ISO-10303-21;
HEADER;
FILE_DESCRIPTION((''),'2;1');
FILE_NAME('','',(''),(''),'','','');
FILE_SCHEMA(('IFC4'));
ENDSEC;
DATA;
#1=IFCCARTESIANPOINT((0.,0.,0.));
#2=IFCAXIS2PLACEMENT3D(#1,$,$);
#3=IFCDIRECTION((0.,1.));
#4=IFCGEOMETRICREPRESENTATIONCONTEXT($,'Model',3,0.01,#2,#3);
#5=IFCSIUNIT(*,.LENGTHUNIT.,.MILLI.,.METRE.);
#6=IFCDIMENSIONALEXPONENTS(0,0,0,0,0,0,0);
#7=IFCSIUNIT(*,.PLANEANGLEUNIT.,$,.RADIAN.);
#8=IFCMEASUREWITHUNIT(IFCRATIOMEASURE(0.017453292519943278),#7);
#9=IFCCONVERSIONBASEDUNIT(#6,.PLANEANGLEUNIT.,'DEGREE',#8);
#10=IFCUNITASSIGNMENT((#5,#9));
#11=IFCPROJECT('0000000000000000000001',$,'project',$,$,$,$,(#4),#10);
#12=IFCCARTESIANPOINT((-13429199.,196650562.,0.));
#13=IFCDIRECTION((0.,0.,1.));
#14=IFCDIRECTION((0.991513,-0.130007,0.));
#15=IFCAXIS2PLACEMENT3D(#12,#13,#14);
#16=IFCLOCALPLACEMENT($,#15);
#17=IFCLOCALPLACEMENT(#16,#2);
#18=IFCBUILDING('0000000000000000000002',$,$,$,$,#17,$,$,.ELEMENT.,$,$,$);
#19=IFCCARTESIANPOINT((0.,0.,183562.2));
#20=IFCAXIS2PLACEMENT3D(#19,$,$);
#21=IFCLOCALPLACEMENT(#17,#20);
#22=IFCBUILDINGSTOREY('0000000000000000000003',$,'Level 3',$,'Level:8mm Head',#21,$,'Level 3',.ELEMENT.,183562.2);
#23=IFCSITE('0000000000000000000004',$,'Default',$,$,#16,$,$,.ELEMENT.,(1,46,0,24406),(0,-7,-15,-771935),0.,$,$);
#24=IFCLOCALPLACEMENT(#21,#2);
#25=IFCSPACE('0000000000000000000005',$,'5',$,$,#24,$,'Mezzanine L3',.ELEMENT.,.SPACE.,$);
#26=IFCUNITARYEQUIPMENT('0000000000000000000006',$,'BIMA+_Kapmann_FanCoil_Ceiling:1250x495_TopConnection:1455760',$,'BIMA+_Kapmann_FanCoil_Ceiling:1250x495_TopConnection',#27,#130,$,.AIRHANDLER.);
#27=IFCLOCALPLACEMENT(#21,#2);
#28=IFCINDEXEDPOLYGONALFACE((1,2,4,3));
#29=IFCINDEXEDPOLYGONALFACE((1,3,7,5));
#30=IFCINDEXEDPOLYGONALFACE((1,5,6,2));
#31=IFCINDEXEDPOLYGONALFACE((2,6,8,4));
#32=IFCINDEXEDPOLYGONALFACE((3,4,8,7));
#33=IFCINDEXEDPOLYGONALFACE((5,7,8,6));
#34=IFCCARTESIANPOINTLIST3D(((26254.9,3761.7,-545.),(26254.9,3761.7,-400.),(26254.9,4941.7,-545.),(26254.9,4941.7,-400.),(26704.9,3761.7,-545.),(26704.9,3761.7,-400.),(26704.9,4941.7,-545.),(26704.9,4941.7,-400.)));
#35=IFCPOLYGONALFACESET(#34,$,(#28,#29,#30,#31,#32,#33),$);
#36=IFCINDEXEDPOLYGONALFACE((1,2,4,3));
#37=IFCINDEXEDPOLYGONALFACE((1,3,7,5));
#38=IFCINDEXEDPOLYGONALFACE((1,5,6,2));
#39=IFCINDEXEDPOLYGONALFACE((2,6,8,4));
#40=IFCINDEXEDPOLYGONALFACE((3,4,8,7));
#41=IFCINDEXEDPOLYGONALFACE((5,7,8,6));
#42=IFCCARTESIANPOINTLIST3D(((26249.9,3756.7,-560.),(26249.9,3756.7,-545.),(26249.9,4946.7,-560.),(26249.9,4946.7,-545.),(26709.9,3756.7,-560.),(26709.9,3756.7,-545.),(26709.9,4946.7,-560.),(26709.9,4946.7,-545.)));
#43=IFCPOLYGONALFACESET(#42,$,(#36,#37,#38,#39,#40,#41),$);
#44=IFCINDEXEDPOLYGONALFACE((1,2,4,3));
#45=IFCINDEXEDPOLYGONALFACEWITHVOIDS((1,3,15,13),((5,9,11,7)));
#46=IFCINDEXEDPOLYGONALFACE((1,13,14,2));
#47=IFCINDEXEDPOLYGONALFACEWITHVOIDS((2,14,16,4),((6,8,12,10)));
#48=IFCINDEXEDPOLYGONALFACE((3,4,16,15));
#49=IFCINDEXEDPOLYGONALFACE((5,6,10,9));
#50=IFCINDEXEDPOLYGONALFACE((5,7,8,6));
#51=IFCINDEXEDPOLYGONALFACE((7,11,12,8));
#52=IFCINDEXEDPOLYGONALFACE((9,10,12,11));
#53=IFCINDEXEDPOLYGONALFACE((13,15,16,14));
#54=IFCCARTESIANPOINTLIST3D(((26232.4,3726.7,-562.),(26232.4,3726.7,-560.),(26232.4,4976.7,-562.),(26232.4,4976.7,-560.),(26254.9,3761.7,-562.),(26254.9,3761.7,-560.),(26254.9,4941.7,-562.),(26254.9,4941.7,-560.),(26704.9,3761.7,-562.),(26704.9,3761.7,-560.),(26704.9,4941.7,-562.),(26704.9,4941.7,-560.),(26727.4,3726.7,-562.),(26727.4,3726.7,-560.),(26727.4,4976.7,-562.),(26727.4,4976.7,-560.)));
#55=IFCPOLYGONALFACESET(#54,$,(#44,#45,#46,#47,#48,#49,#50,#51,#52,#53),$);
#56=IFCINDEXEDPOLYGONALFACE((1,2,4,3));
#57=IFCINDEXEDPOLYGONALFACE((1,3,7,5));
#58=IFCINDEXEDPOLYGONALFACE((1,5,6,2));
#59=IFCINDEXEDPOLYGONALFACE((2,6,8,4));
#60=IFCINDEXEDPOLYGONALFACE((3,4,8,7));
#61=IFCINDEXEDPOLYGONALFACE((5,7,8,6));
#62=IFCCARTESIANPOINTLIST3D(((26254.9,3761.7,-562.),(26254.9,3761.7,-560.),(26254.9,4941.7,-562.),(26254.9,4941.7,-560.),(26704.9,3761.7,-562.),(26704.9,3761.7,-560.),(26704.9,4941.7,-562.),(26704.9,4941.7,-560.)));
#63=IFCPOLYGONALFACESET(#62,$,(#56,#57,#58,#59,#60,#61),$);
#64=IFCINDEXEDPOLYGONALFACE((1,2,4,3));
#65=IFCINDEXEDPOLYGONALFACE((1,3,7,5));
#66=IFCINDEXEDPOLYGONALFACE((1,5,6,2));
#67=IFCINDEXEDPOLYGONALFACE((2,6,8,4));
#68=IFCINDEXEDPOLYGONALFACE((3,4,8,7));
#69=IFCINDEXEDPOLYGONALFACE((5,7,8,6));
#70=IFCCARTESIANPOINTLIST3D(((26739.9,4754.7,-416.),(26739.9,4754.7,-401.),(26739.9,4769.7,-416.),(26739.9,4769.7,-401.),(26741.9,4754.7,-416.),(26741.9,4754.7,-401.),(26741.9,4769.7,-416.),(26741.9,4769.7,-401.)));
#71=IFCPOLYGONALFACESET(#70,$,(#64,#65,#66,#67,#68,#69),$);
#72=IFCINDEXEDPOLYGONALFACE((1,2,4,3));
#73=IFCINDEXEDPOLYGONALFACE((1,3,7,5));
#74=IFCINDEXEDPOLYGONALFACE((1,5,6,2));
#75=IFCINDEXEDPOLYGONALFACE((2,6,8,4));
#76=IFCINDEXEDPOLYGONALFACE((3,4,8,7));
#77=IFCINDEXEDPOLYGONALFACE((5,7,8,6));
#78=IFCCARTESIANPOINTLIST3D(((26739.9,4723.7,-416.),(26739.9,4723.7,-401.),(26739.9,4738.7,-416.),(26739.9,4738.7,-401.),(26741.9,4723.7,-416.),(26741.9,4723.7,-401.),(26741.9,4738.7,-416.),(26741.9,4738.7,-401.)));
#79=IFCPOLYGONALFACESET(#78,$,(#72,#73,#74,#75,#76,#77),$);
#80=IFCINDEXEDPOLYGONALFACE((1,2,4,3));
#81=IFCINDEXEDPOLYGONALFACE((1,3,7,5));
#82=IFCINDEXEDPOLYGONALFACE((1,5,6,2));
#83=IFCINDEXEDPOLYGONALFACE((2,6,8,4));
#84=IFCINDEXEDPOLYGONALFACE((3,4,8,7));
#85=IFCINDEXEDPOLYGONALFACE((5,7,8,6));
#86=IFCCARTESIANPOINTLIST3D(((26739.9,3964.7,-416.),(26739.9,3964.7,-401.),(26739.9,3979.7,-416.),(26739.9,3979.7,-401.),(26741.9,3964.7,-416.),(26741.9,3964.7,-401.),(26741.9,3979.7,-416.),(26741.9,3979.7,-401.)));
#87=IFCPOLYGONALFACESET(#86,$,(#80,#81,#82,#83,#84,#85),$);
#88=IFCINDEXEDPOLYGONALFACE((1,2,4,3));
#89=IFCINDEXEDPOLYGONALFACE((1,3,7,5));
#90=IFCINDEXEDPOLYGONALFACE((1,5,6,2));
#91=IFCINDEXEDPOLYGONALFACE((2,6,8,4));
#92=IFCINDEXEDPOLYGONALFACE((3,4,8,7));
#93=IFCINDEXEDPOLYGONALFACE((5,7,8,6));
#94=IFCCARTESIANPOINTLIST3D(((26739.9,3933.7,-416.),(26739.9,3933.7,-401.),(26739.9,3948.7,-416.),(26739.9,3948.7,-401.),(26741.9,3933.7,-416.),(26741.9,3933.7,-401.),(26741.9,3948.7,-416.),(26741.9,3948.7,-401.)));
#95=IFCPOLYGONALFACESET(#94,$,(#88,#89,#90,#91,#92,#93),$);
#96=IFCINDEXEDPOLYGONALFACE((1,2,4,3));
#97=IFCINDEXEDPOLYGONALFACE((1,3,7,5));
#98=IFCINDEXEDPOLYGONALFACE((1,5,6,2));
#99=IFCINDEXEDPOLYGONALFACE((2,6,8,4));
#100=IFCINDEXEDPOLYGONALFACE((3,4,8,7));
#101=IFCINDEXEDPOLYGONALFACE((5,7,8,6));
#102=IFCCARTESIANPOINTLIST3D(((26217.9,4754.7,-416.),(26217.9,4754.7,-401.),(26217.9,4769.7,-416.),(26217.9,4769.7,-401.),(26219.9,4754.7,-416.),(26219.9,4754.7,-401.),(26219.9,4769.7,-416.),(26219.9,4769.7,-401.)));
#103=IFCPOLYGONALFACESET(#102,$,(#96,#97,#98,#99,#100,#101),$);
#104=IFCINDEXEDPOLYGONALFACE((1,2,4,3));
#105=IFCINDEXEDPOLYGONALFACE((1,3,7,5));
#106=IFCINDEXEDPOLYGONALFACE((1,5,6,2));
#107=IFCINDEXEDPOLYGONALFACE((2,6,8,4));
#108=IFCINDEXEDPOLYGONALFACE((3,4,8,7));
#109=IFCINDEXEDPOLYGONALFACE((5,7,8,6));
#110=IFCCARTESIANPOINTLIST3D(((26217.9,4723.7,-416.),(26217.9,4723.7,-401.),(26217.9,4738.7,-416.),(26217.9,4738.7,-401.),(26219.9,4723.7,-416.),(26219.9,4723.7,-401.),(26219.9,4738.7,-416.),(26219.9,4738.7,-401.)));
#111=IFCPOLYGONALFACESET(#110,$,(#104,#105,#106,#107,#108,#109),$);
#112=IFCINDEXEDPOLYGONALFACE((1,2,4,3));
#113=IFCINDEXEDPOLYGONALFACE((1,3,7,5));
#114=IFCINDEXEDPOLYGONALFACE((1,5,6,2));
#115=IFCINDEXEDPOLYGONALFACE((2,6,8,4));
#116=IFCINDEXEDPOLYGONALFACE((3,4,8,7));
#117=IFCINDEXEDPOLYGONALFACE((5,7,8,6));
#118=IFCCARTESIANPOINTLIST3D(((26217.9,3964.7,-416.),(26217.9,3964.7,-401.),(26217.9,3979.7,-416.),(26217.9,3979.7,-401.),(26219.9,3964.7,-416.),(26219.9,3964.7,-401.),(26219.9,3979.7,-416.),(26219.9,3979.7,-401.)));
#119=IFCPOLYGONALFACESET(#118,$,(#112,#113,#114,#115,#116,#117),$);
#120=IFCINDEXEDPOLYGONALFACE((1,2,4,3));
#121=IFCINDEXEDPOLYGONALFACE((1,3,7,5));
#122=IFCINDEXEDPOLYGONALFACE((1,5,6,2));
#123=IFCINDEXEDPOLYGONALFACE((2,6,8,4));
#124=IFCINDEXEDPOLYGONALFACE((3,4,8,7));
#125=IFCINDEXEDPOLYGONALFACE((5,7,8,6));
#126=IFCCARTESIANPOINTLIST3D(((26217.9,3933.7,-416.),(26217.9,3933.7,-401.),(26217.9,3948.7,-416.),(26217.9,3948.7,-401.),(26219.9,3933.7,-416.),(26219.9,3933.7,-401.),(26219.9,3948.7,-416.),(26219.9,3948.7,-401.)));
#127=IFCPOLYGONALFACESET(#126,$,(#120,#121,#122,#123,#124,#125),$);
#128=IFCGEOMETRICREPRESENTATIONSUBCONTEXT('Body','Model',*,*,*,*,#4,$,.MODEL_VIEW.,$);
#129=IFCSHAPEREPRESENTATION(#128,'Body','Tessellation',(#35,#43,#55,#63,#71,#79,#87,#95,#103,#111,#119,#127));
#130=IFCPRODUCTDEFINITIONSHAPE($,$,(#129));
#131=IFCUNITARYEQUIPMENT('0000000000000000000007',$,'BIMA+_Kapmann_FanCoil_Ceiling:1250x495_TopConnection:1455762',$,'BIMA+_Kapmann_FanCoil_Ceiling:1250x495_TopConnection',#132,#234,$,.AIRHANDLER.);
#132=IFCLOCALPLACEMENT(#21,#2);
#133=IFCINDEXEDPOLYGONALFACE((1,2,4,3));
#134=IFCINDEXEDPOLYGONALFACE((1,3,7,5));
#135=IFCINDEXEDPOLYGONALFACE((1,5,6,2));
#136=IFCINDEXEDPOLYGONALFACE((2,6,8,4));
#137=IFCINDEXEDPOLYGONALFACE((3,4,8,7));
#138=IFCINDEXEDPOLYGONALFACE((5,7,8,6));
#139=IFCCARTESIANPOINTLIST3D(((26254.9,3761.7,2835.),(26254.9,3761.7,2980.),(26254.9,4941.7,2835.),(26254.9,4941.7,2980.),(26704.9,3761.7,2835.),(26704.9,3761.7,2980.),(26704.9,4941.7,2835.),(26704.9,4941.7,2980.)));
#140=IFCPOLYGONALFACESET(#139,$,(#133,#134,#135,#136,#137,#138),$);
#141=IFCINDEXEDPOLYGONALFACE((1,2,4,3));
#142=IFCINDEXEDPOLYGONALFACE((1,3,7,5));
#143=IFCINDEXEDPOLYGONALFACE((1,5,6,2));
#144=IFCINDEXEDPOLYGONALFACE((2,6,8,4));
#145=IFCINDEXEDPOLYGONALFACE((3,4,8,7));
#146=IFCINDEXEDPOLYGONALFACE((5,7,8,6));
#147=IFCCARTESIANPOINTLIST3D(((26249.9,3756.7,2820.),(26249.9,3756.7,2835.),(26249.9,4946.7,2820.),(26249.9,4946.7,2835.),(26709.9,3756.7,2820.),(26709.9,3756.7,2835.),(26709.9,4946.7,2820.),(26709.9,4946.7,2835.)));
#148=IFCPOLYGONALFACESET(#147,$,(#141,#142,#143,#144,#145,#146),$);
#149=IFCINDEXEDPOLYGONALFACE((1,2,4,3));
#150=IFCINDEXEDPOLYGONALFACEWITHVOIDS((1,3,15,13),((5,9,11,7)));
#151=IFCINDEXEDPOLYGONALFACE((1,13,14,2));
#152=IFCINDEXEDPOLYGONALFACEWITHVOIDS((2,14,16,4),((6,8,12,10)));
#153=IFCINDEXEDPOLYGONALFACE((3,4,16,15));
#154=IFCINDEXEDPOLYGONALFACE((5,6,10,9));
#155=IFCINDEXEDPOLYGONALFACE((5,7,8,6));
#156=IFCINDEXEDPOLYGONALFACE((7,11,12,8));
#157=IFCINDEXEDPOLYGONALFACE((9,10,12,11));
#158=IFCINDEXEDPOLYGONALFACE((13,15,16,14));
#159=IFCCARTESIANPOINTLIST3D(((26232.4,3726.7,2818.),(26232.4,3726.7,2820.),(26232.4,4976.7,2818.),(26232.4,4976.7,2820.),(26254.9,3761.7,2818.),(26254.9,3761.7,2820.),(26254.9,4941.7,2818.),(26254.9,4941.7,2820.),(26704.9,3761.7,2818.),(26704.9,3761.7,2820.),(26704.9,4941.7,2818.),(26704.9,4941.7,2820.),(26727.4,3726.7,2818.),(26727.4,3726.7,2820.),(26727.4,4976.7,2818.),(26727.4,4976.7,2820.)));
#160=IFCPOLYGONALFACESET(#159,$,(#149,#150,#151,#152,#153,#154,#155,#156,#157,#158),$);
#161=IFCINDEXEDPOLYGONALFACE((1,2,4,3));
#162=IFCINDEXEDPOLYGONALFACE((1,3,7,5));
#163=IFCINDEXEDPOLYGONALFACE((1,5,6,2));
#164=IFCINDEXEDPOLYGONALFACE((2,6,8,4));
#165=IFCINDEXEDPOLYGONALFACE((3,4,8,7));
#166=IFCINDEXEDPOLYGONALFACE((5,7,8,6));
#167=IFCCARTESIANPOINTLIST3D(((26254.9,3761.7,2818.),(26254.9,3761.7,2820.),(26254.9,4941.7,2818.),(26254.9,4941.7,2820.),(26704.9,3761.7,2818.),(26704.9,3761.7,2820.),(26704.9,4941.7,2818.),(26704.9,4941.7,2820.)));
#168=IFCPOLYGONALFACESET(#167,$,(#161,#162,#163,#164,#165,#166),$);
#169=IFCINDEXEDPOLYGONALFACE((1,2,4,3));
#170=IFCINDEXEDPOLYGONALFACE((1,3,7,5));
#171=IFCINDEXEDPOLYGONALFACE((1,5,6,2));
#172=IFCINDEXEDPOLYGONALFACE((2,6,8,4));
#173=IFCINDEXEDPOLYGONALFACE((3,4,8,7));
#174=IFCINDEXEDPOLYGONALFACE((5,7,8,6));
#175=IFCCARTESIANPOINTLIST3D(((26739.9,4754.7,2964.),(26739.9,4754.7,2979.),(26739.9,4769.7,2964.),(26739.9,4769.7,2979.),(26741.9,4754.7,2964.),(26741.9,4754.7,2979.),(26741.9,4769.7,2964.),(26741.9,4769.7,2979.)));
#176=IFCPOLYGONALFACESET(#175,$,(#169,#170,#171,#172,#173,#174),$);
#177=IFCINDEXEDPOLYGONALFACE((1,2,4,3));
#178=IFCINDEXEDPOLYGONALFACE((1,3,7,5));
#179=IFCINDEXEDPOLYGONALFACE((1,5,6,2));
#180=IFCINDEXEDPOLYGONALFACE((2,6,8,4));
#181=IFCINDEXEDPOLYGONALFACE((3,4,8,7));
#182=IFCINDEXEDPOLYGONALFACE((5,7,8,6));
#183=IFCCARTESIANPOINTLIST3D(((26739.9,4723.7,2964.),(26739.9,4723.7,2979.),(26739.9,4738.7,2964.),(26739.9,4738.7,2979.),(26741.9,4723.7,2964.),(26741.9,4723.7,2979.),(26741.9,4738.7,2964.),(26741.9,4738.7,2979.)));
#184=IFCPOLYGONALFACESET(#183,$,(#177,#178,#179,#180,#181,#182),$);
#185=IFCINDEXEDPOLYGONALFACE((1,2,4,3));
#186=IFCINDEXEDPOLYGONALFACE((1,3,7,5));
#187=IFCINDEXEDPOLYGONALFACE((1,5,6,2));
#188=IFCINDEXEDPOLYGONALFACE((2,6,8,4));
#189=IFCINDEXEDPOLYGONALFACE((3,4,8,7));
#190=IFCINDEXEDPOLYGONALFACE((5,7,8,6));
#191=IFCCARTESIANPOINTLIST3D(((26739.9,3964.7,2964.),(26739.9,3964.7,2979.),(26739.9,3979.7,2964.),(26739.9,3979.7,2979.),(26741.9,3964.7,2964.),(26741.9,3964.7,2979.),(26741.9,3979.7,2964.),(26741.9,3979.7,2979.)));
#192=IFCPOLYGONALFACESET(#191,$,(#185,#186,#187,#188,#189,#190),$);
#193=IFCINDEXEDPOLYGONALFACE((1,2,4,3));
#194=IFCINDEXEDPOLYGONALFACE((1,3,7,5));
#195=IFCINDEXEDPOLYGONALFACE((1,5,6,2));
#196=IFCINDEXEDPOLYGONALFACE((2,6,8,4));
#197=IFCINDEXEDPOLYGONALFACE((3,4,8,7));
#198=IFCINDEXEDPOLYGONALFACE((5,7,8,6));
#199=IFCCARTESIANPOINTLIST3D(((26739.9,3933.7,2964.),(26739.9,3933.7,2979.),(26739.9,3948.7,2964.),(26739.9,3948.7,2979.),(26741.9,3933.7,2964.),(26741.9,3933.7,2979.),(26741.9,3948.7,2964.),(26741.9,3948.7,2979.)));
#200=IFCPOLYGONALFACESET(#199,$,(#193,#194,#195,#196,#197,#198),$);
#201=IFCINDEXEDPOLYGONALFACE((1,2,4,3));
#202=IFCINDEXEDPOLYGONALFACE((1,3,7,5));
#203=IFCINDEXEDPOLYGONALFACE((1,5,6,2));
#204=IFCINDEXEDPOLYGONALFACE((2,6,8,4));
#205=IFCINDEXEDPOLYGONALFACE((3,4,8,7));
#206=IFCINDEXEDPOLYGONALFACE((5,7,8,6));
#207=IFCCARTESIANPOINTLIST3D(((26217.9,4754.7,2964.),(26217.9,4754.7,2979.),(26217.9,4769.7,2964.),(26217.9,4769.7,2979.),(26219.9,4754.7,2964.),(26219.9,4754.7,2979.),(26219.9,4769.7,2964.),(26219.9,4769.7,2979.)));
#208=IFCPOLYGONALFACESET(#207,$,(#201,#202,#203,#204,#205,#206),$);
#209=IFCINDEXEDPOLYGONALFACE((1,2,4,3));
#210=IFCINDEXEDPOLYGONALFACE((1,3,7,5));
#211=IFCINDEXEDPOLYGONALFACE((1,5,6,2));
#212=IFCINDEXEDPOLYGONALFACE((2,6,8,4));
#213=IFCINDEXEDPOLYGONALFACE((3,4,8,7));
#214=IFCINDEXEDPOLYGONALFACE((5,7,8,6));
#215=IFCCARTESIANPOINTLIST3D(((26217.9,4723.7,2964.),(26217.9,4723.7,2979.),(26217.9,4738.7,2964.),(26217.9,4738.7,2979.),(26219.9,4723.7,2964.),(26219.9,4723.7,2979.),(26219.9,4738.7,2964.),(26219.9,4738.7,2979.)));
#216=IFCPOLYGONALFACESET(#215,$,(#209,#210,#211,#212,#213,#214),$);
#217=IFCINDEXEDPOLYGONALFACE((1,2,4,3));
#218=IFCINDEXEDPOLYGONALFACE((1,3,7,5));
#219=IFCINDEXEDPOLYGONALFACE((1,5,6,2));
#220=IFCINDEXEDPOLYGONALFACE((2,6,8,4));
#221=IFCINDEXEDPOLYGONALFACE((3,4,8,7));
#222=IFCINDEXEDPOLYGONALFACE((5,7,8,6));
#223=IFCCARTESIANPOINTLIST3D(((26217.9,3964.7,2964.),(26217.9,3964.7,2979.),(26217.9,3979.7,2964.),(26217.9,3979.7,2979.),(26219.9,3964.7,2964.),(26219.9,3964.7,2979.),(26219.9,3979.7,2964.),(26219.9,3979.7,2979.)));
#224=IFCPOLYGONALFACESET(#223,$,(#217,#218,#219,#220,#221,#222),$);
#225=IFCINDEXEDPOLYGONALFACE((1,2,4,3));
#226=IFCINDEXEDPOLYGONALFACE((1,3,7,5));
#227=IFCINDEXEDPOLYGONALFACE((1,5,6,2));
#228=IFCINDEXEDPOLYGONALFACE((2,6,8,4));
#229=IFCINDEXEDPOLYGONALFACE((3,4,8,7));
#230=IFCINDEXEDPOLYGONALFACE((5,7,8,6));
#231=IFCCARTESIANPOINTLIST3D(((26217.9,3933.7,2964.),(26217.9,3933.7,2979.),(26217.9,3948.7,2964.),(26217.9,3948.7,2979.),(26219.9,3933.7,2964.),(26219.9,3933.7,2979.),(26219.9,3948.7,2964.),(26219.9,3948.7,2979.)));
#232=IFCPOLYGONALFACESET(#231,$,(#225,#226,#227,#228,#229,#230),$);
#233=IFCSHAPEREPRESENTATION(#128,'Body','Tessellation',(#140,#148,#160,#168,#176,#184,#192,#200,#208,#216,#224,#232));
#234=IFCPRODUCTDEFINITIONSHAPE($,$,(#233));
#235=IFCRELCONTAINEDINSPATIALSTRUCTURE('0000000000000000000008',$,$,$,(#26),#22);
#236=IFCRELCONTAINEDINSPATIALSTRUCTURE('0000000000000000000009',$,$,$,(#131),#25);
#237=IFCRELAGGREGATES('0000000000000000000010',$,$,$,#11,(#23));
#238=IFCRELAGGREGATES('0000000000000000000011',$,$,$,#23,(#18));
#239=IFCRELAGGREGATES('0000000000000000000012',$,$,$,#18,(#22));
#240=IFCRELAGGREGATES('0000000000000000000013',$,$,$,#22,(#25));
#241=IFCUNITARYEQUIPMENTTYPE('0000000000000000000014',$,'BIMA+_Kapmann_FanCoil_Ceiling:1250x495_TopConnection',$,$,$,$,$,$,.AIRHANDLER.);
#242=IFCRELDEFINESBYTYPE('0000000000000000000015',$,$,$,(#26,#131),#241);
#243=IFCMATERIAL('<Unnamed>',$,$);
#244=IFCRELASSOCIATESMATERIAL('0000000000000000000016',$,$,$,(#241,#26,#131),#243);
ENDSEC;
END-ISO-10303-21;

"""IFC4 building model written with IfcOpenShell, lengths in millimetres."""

from ifc_helpers import new_model, entity, si_unit, converted_unit, direction, frame, origin, place, context, subcontext, project, spatial, indexed_curve, outline, extrude, source, transform, mapped, material, type_object, type_shapes, element, save


model = new_model("IFC4")

# Units and contexts
model_context = context("Model", 3, precision=0.01, world=origin(), true_north=direction((0.0, 1.0)))
body_context = subcontext(model_context, "Body", "Model", "MODEL_VIEW")
ifc_project = project(units=[si_unit("LENGTHUNIT", "METRE", prefix="MILLI"), converted_unit("PLANEANGLEUNIT", "DEGREE", entity("IfcRatioMeasure", 0.017453292519943278), si_unit("PLANEANGLEUNIT", "RADIAN"), dimensions=[0, 0, 0, 0, 0, 0, 0])], contexts=[model_context])

# Site, building, storey
site_placement = place(None, frame((-13429199.0, 196650562.0, 0.0), z_axis=(0.0, 0.0, 1.0), x_axis=(0.991513, -0.130007, 0.0)))
site = spatial("IfcSite", under=ifc_project, at=site_placement, Name="Default", CompositionType="ELEMENT", RefLatitude=(1, 46, 0, 24406), RefLongitude=(0, -7, -15, -771935), RefElevation=0.0)
building_placement = place(site_placement, origin())
building = spatial("IfcBuilding", under=site, at=building_placement, CompositionType="ELEMENT")
storey_placement = place(building_placement, frame((0.0, 0.0, 183562.2)))
storey = spatial("IfcBuildingStorey", under=building, at=storey_placement, Name="Level 3", ObjectType="Level:8mm Head", LongName="Level 3", CompositionType="ELEMENT", Elevation=183562.2)

# Shared definitions
ifc_material_1 = material(Name="<Unnamed>")
unitary_equipment_type = type_object("IfcUnitaryEquipmentType", Name="BIMA+_Kapmann_FanCoil_Ceiling:1250x495_TopConnection", PredefinedType="AIRHANDLER", material=ifc_material_1)
shared_shape = source(origin(), body_context, "Body", "SweptSolid", [
    extrude(outline(indexed_curve([(-590.0, -225.0), (590.0, -225.0), (590.0, 225.0), (-590.0, 225.0), (-590.0, -225.0)], self_intersect=False)), frame((0.0, 0.0, 15.0)), (0.0, 0.0, 1.0), 145.0),
    extrude(outline(indexed_curve([(-595.0, -230.0), (595.0, -230.0), (595.0, 230.0), (-595.0, 230.0), (-595.0, -230.0)], self_intersect=False)), frame((0.0, 0.0, 0.0), z_axis=(0.0, 0.0, 1.0), x_axis=(-1.0, 0.0, 0.0)), (0.0, 0.0, 1.0), 15.0),
    extrude(outline(indexed_curve([(-625.0, -247.5), (625.0, -247.5), (625.0, 247.5), (-625.0, 247.5), (-625.0, -247.5)], self_intersect=False), holes=[indexed_curve([(-590.0, -225.0), (-590.0, 225.0), (590.0, 225.0), (590.0, -225.0), (-590.0, -225.0)], self_intersect=False)]), frame((0.0, 0.0, -2.0), z_axis=(0.0, 0.0, 1.0), x_axis=(-1.0, 0.0, 0.0)), (0.0, 0.0, 1.0), 2.0),
    extrude(outline(indexed_curve([(-590.0, -225.0), (590.0, -225.0), (590.0, 225.0), (-590.0, 225.0), (-590.0, -225.0)], self_intersect=False)), frame((0.0, 0.0, -2.0), z_axis=(0.0, 0.0, 1.0), x_axis=(-1.0, 0.0, 0.0)), (0.0, 0.0, 1.0), 2.0),
    extrude(outline(indexed_curve([(-1.0, -7.5), (1.0, -7.5), (1.0, 7.5), (-1.0, 7.5), (-1.0, -7.5)], self_intersect=False)), frame((-410.5, 261.0, 144.0), z_axis=(0.0, 0.0, 1.0), x_axis=(0.0, -1.0, 0.0)), (0.0, 0.0, 1.0), 15.0),
    extrude(outline(indexed_curve([(-1.0, -7.5), (1.0, -7.5), (1.0, 7.5), (-1.0, 7.5), (-1.0, -7.5)], self_intersect=False)), frame((-379.5, 261.0, 144.0), z_axis=(0.0, 0.0, 1.0), x_axis=(0.0, -1.0, 0.0)), (0.0, 0.0, 1.0), 15.0),
    extrude(outline(indexed_curve([(-1.0, -7.5), (1.0, -7.5), (1.0, 7.5), (-1.0, 7.5), (-1.0, -7.5)], self_intersect=False)), frame((379.5, 261.0, 144.0), z_axis=(0.0, 0.0, 1.0), x_axis=(0.0, -1.0, 0.0)), (0.0, 0.0, 1.0), 15.0),
    extrude(outline(indexed_curve([(-1.0, -7.5), (1.0, -7.5), (1.0, 7.5), (-1.0, 7.5), (-1.0, -7.5)], self_intersect=False)), frame((410.5, 261.0, 144.0), z_axis=(0.0, 0.0, 1.0), x_axis=(0.0, -1.0, 0.0)), (0.0, 0.0, 1.0), 15.0),
    extrude(outline(indexed_curve([(-1.0, -7.5), (1.0, -7.5), (1.0, 7.5), (-1.0, 7.5), (-1.0, -7.5)], self_intersect=False)), frame((-410.5, -261.0, 144.0), z_axis=(0.0, 0.0, 1.0), x_axis=(0.0, -1.0, 0.0)), (0.0, 0.0, 1.0), 15.0),
    extrude(outline(indexed_curve([(-1.0, -7.5), (1.0, -7.5), (1.0, 7.5), (-1.0, 7.5), (-1.0, -7.5)], self_intersect=False)), frame((-379.5, -261.0, 144.0), z_axis=(0.0, 0.0, 1.0), x_axis=(0.0, -1.0, 0.0)), (0.0, 0.0, 1.0), 15.0),
    extrude(outline(indexed_curve([(-1.0, -7.5), (1.0, -7.5), (1.0, 7.5), (-1.0, 7.5), (-1.0, -7.5)], self_intersect=False)), frame((379.5, -261.0, 144.0), z_axis=(0.0, 0.0, 1.0), x_axis=(0.0, -1.0, 0.0)), (0.0, 0.0, 1.0), 15.0),
    extrude(outline(indexed_curve([(-1.0, -7.5), (1.0, -7.5), (1.0, 7.5), (-1.0, 7.5), (-1.0, -7.5)], self_intersect=False)), frame((410.5, -261.0, 144.0), z_axis=(0.0, 0.0, 1.0), x_axis=(0.0, -1.0, 0.0)), (0.0, 0.0, 1.0), 15.0),
])
type_shapes(unitary_equipment_type, [shared_shape])

# Shared definitions
space_placement = place(storey_placement, origin())
space = spatial("IfcSpace", under=storey, at=space_placement, Name="5", LongName="Mezzanine L3", CompositionType="ELEMENT", PredefinedType="SPACE")

# Unitary equipment
unitary_equipment_1_placement = place(storey_placement, frame((26479.9, 4351.7, -560.0), z_axis=(0.0, 0.0, 1.0), x_axis=(0.0, -1.0, 0.0)))
element("IfcUnitaryEquipment", 1, at=unitary_equipment_1_placement, inside=storey, type_object=unitary_equipment_type, material=ifc_material_1, Name="BIMA+_Kapmann_FanCoil_Ceiling:1250x495_TopConnection:1455760", ObjectType="BIMA+_Kapmann_FanCoil_Ceiling:1250x495_TopConnection", PredefinedType="AIRHANDLER", context=body_context, shape_type="MappedRepresentation", body=[
    mapped(shared_shape, transform((0.0, 0.0, 0.0), scale=1.0)),
])
unitary_equipment_2_placement = place(space_placement, frame((26479.9, 4351.7, 2820.0), z_axis=(0.0, 0.0, 1.0), x_axis=(0.0, -1.0, 0.0)))
element("IfcUnitaryEquipment", 2, at=unitary_equipment_2_placement, inside=space, type_object=unitary_equipment_type, material=ifc_material_1, Name="BIMA+_Kapmann_FanCoil_Ceiling:1250x495_TopConnection:1455762", ObjectType="BIMA+_Kapmann_FanCoil_Ceiling:1250x495_TopConnection", PredefinedType="AIRHANDLER", context=body_context, shape_type="MappedRepresentation", body=[
    mapped(shared_shape, transform((0.0, 0.0, 0.0), scale=1.0)),
])

save(model, "model.ifc")
